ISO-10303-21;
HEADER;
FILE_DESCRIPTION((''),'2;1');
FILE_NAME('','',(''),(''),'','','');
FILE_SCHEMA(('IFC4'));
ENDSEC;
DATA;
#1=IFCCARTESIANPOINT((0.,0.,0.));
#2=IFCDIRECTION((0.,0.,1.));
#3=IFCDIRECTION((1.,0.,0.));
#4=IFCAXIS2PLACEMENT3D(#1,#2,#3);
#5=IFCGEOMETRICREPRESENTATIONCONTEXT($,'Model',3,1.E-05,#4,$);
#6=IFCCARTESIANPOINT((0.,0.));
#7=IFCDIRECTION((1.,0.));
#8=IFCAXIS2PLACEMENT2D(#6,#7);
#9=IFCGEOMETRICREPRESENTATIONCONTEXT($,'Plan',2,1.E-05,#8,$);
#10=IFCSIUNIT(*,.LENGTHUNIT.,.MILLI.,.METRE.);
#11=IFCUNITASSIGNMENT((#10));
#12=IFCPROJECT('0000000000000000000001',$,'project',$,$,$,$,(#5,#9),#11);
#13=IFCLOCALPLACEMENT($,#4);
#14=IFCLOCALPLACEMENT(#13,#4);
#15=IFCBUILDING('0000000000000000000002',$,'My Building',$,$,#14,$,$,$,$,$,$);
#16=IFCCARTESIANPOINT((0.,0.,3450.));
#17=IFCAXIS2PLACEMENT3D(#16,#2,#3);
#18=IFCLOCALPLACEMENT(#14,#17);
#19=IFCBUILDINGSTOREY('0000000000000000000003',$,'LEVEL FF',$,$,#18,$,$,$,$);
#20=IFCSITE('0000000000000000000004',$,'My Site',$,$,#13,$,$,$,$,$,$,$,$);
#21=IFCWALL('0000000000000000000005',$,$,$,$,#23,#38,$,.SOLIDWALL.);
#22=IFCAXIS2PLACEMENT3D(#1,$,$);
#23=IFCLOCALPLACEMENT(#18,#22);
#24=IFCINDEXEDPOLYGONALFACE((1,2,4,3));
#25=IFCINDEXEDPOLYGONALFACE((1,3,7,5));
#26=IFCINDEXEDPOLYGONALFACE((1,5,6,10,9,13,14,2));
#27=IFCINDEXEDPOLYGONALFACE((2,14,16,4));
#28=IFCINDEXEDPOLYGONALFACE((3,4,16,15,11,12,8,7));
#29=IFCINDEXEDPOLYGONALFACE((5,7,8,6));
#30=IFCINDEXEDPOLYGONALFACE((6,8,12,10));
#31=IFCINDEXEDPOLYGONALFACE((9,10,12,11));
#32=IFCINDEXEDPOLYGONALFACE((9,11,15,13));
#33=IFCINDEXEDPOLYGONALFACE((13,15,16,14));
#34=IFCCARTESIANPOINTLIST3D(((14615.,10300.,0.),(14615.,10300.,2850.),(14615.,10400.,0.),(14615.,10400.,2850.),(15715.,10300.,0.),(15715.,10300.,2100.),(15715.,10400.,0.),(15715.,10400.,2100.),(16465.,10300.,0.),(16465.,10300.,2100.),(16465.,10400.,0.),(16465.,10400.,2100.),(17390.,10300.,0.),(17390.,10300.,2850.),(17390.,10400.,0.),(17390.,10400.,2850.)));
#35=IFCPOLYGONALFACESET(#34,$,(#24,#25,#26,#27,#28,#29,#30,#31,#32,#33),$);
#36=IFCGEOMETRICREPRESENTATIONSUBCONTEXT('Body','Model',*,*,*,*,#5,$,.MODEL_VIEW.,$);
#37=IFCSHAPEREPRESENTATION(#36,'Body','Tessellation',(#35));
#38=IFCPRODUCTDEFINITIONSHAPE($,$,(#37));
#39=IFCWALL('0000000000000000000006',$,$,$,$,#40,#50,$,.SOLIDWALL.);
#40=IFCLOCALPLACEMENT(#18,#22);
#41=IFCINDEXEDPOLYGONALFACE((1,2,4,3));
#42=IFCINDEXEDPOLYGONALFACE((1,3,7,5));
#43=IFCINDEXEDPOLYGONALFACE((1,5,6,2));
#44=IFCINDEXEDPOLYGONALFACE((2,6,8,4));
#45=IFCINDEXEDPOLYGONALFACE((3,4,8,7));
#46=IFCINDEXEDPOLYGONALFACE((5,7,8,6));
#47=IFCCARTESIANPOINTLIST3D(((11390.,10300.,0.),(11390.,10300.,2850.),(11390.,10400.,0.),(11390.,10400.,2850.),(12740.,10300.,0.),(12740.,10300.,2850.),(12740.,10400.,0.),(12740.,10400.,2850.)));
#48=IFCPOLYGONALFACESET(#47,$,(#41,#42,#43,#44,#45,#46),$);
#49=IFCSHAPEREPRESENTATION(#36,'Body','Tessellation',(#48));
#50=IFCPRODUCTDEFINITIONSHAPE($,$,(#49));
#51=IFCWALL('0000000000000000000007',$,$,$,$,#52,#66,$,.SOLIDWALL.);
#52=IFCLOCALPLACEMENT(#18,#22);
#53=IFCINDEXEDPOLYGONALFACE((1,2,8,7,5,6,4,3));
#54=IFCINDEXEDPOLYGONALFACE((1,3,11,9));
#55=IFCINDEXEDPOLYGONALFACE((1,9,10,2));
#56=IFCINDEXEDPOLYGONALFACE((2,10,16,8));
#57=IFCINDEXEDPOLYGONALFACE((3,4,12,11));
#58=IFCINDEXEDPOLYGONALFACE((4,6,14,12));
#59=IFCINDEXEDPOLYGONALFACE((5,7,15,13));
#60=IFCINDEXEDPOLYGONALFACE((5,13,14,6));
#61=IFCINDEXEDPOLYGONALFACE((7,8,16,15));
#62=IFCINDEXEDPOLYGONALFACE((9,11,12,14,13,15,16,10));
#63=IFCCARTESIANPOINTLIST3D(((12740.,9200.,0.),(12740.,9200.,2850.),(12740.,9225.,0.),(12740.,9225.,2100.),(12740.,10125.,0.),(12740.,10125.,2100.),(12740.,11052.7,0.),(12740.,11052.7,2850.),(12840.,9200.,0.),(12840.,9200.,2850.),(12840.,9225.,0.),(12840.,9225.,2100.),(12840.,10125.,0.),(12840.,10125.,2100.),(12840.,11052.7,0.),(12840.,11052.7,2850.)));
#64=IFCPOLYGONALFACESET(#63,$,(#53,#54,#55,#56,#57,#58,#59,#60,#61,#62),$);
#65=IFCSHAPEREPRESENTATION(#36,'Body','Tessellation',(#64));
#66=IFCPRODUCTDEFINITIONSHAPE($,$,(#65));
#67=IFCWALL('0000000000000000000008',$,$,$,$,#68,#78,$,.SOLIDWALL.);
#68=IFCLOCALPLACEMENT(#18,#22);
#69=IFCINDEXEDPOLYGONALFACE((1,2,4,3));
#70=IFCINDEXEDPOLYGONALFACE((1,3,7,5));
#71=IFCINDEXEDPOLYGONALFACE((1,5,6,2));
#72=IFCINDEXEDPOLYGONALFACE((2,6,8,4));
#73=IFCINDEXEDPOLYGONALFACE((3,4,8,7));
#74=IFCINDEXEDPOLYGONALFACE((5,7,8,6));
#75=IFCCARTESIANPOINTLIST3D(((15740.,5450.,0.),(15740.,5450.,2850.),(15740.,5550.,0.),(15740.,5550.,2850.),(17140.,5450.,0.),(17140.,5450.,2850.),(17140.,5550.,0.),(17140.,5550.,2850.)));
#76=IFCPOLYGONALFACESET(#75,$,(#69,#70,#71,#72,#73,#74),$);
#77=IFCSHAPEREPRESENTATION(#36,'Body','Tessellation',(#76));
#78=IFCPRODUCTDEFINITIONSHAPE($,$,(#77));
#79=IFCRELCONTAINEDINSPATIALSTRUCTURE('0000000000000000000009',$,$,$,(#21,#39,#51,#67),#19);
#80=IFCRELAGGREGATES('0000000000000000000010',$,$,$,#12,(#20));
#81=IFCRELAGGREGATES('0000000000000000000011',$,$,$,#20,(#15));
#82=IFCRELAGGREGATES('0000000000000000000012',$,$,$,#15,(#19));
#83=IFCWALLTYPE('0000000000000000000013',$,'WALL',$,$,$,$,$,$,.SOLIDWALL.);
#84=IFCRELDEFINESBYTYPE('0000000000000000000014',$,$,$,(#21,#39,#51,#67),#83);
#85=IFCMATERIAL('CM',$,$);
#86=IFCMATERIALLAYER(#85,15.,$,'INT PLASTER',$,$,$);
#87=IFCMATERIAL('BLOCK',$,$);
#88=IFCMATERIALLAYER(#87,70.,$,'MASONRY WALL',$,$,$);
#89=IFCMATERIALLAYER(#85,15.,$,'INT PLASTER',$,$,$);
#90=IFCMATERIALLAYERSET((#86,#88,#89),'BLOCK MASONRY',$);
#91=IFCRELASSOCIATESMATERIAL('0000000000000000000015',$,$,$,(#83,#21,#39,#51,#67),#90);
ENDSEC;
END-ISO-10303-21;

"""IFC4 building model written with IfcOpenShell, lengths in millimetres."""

from ifc_helpers import new_model, si_unit, frame, origin_with_axes, origin_2d_with_axis, place, context, subcontext, project, spatial, indexed_curve, outline, extrude, material, layer, layer_set, layer_usage, type_object, element, save


model = new_model("IFC4")

# Units and contexts
model_context = context("Model", 3, precision=1e-05, world=origin_with_axes())
plan_context = context("Plan", 2, precision=1e-05, world=origin_2d_with_axis())
body_context = subcontext(model_context, "Body", "Model", "MODEL_VIEW")
ifc_project = project(units=[si_unit("LENGTHUNIT", "METRE", prefix="MILLI")], contexts=[model_context, plan_context])

# Site, building, storey
site_placement = place(None, origin_with_axes())
site = spatial("IfcSite", under=ifc_project, at=site_placement, Name="My Site")
building_placement = place(site_placement, origin_with_axes())
building = spatial("IfcBuilding", under=site, at=building_placement, Name="My Building")
storey_placement = place(building_placement, frame((0.0, 0.0, 3450.0), z_axis=(0.0, 0.0, 1.0), x_axis=(1.0, 0.0, 0.0)))
storey = spatial("IfcBuildingStorey", under=building, at=storey_placement, Name="LEVEL FF")

# Shared definitions
ifc_material_1 = material(Name="CM")
ifc_layer_1 = layer(ifc_material_1, 15.0, Name="INT PLASTER")
ifc_material_2 = material(Name="BLOCK")
ifc_layer_2 = layer(ifc_material_2, 70.0, Name="MASONRY WALL")
ifc_layer_3 = layer(ifc_material_1, 15.0, Name="INT PLASTER")
ifc_layer_set = layer_set([ifc_layer_1, ifc_layer_2, ifc_layer_3], Name="BLOCK MASONRY")
wall_type = type_object("IfcWallType", Name="WALL", PredefinedType="SOLIDWALL", material=ifc_layer_set)

# Wall, opening
ifc_layer_usage_1 = layer_usage(ifc_layer_set, "AXIS2", "POSITIVE", 0.0)
wall_1_placement = place(storey_placement, frame((14615.0, 10400.0, 0.0), z_axis=(0.0, 0.0, 1.0), x_axis=(0.0, -1.0, 0.0)))
wall_1 = element("IfcWall", 1, at=wall_1_placement, inside=storey, type_object=wall_type, material=ifc_layer_usage_1, PredefinedType="SOLIDWALL", context=body_context, shape_type="SweptSolid", body=[
    extrude(outline(indexed_curve([(0.0, 0.0), (0.0, 2775.0), (100.0, 2775.0), (100.0, 0.0), (0.0, 0.0)], self_intersect=False)), origin_with_axes(), (0.0, 0.0, 1.0), 2850.0),
])
opening_1_placement = place(wall_1_placement, frame((0.0, 1850.0, 0.0), z_axis=(0.0, 0.0, 1.0), x_axis=(0.0, -1.0, 0.0)))
element("IfcOpeningElement", 2, at=opening_1_placement, cuts=wall_1, PredefinedType="OPENING", context=body_context, shape_type="SweptSolid", body=[
    extrude(outline(indexed_curve([(0.0, 0.0), (0.0, 400.0), (750.0, 400.0), (750.0, 0.0), (0.0, 0.0)], self_intersect=False)), frame((0.0, -100.0, 0.0), z_axis=(0.0, 0.0, 1.0), x_axis=(1.0, 0.0, 0.0)), (0.0, 0.0, 1.0), 2100.0),
])

# Wall
ifc_layer_usage_2 = layer_usage(ifc_layer_set, "AXIS2", "POSITIVE", 0.0)
wall_2_placement = place(storey_placement, frame((11390.0, 10400.0, 0.0), z_axis=(0.0, 0.0, 1.0), x_axis=(0.0, -1.0, 0.0)))
element("IfcWall", 3, at=wall_2_placement, inside=storey, type_object=wall_type, material=ifc_layer_usage_2, PredefinedType="SOLIDWALL", context=body_context, shape_type="SweptSolid", body=[
    extrude(outline(indexed_curve([(0.0, 0.0), (0.0, 1350.0), (100.0, 1350.0), (100.0, 0.0), (0.0, 0.0)], self_intersect=False)), origin_with_axes(), (0.0, 0.0, 1.0), 2850.0),
])

# Wall, opening
ifc_layer_usage_3 = layer_usage(ifc_layer_set, "AXIS2", "POSITIVE", 0.0)
wall_3_placement = place(storey_placement, frame((12840.0, 9200.0, 0.0), z_axis=(0.0, 0.0, 1.0), x_axis=(0.0, 1.0, 0.0)))
wall_3 = element("IfcWall", 4, at=wall_3_placement, inside=storey, type_object=wall_type, material=ifc_layer_usage_3, PredefinedType="SOLIDWALL", context=body_context, shape_type="SweptSolid", body=[
    extrude(outline(indexed_curve([(0.0, 0.0), (0.0, 100.0), (1852.7, 100.0), (1852.7, 0.0), (0.0, 0.0)], self_intersect=False)), origin_with_axes(), (0.0, 0.0, 1.0), 2850.0),
])
opening_2_placement = place(wall_3_placement, frame((925.0, 100.0, 0.0), z_axis=(0.0, 0.0, 1.0), x_axis=(-1.0, 0.0, 0.0)))
element("IfcOpeningElement", 5, at=opening_2_placement, cuts=wall_3, PredefinedType="OPENING", context=body_context, shape_type="SweptSolid", body=[
    extrude(outline(indexed_curve([(0.0, 0.0), (0.0, 400.0), (900.0, 400.0), (900.0, 0.0), (0.0, 0.0)], self_intersect=False)), frame((0.0, -100.0, 0.0), z_axis=(0.0, 0.0, 1.0), x_axis=(1.0, 0.0, 0.0)), (0.0, 0.0, 1.0), 2100.0),
])

# Wall
ifc_layer_usage_4 = layer_usage(ifc_layer_set, "AXIS2", "POSITIVE", 0.0)
wall_4_placement = place(storey_placement, frame((15740.0, 5550.0, 0.0), z_axis=(0.0, 0.0, 1.0), x_axis=(0.0, -1.0, 0.0)))
element("IfcWall", 6, at=wall_4_placement, inside=storey, type_object=wall_type, material=ifc_layer_usage_4, PredefinedType="SOLIDWALL", context=body_context, shape_type="SweptSolid", body=[
    extrude(outline(indexed_curve([(0.0, 0.0), (0.0, 1400.0), (100.0, 1400.0), (100.0, 0.0), (0.0, 0.0)], self_intersect=False)), origin_with_axes(), (0.0, 0.0, 1.0), 2850.0),
])

save(model, "model.ifc")
